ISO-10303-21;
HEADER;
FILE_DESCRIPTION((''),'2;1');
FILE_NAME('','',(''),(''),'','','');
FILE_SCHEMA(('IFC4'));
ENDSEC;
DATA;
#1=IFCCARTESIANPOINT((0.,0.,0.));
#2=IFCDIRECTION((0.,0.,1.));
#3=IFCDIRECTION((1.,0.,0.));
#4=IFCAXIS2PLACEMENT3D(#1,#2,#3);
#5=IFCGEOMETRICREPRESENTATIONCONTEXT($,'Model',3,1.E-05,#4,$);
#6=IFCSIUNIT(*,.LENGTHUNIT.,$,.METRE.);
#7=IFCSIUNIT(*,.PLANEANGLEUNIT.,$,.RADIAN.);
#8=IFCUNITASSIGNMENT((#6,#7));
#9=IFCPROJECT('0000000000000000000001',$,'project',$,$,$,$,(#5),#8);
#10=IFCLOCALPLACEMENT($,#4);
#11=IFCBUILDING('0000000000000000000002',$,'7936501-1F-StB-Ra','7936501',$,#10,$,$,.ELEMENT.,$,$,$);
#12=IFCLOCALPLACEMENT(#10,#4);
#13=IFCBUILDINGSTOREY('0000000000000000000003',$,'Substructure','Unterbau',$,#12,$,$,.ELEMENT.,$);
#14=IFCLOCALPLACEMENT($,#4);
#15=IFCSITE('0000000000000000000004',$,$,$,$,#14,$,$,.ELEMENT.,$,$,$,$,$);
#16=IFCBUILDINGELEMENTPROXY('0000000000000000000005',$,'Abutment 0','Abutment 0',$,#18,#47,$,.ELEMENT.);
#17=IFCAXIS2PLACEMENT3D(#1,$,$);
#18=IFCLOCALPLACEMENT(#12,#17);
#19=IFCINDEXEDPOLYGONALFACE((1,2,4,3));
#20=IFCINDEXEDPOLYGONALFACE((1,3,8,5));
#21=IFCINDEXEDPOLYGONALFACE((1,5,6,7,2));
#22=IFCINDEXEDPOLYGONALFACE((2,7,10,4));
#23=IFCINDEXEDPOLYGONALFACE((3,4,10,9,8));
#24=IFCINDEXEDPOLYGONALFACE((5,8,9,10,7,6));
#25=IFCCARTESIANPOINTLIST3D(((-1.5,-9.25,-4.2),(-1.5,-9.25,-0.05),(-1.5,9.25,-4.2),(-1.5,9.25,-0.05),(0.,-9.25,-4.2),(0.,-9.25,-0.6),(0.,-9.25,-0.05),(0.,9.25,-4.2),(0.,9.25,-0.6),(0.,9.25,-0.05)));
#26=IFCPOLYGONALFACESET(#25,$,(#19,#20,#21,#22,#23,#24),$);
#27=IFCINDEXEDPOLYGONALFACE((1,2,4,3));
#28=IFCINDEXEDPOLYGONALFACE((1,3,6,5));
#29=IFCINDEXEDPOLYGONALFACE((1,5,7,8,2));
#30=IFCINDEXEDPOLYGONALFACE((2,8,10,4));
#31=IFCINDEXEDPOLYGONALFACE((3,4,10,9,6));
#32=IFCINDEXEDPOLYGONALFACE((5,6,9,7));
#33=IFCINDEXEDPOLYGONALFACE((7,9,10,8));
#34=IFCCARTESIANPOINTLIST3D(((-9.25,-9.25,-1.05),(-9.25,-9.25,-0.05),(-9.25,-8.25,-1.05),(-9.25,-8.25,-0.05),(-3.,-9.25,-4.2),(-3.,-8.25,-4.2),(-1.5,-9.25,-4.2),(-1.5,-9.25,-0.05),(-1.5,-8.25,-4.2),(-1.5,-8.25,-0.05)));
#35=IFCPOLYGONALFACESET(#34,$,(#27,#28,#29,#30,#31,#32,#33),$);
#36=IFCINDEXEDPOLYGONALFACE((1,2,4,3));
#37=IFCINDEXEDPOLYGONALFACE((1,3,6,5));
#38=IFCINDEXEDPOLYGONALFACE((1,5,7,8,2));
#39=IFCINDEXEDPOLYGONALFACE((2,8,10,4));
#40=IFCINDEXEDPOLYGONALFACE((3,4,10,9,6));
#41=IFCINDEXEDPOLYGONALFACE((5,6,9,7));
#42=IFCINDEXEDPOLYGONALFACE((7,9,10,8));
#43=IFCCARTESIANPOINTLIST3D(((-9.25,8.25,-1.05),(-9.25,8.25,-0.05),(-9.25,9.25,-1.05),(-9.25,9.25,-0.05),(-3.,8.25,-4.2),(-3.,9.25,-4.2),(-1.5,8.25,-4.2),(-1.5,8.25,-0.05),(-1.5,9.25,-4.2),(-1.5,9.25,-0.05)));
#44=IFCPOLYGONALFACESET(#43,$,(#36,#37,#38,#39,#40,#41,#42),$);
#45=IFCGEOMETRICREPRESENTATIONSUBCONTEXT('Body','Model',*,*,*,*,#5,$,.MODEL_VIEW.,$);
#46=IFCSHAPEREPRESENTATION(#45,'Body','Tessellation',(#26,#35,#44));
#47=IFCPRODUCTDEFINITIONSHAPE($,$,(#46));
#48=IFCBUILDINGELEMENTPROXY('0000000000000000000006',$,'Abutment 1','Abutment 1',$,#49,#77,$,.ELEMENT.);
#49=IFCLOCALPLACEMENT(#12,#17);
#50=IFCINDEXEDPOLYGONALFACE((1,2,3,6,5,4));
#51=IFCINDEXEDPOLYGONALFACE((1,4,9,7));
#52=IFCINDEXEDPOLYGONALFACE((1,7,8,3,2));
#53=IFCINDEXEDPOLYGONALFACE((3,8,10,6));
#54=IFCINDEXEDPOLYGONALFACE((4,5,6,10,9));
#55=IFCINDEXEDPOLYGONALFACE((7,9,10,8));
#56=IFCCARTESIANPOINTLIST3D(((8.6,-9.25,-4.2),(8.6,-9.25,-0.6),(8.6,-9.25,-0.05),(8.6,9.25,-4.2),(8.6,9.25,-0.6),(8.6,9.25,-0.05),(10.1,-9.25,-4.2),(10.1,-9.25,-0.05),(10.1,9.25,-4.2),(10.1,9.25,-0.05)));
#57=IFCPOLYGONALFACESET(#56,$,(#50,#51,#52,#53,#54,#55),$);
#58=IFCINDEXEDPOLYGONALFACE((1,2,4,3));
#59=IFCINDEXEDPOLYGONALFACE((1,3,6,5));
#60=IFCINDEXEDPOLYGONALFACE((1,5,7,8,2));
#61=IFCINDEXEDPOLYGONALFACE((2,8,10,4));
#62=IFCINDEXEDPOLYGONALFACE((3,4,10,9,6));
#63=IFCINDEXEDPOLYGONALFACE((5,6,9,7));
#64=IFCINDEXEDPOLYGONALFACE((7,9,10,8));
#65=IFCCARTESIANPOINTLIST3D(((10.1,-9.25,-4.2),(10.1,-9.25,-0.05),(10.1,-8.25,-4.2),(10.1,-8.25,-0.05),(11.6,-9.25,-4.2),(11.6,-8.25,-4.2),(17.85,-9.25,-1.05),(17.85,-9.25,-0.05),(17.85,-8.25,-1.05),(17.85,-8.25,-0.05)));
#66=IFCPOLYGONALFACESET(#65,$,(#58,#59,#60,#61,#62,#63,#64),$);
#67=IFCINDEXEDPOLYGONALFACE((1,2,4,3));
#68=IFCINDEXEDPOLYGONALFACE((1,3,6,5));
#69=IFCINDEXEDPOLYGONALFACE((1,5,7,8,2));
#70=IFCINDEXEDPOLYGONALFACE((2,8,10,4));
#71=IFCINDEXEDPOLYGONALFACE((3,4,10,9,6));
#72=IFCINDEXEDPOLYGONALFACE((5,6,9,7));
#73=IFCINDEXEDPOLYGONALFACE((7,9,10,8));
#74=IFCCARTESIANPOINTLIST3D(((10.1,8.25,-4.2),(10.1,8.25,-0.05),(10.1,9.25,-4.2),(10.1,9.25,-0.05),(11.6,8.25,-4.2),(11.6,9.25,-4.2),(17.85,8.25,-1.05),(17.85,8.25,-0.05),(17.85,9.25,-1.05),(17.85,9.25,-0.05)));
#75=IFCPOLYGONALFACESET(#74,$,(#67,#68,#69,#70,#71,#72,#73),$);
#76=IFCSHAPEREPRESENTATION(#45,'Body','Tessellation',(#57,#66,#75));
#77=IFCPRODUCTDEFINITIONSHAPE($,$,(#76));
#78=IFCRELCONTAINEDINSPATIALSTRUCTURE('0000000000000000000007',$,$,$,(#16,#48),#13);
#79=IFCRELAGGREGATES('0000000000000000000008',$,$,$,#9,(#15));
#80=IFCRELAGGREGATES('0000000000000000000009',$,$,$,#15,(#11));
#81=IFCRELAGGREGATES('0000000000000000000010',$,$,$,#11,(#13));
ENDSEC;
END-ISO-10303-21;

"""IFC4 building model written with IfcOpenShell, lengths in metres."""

from ifc_helpers import new_model, si_unit, frame, origin_with_axes, place, context, subcontext, project, spatial, polyline, outline, extrude, element, save


model = new_model("IFC4")

# Units and contexts
model_context = context("Model", 3, precision=1e-05, world=origin_with_axes())
body_context = subcontext(model_context, "Body", "Model", "MODEL_VIEW")
ifc_project = project(units=[si_unit("LENGTHUNIT", "METRE"), si_unit("PLANEANGLEUNIT", "RADIAN")], contexts=[model_context])

# Site, building, storey
site_placement = place(None, origin_with_axes())
site = spatial("IfcSite", under=ifc_project, at=site_placement, CompositionType="ELEMENT")
building_placement = place(None, origin_with_axes())
building = spatial("IfcBuilding", under=site, at=building_placement, Name="7936501-1F-StB-Ra", Description="7936501", CompositionType="ELEMENT")
storey_placement = place(building_placement, origin_with_axes())
storey = spatial("IfcBuildingStorey", under=building, at=storey_placement, Name="Substructure", Description="Unterbau", CompositionType="ELEMENT")

# Building element proxies
placement_1 = place(building_placement, origin_with_axes())
placement_2 = place(placement_1, frame((0.0, 0.0, 0.0), z_axis=(1.0, 0.0, 0.0), x_axis=(0.0, 1.0, 0.0)))
proxy_1_placement = place(placement_2, frame((-9.25, -0.6, 0.0), z_axis=(1.0, 0.0, 0.0), x_axis=(0.0, 0.0, 1.0)))
element("IfcBuildingElementProxy", 1, at=proxy_1_placement, inside=storey, Name="Abutment 0", Description="Abutment 0", PredefinedType="ELEMENT", context=body_context, shape_type="SweptSolid", body=[
    extrude(outline(polyline([(0.0, 0.0), (0.0, 3.6), (-1.5, 3.6), (-1.5, -0.55), (0.0, -0.55), (0.0, 0.0)])), origin_with_axes(), (0.0, 0.0, 1.0), 18.5),
    extrude(outline(polyline([(-1.5, -0.55), (-1.5, 3.6), (-3.0, 3.6), (-9.25, 0.45), (-9.25, -0.55), (-1.5, -0.55)])), origin_with_axes(), (0.0, 0.0, 1.0), 1.0),
    extrude(outline(polyline([(-1.5, -0.55), (-1.5, 3.6), (-3.0, 3.6), (-9.25, 0.45), (-9.25, -0.55), (-1.5, -0.55)])), frame((0.0, 0.0, 17.5), z_axis=(0.0, 0.0, 1.0), x_axis=(1.0, 0.0, 0.0)), (0.0, 0.0, 1.0), 1.0),
])
proxy_2_placement = place(placement_2, frame((-9.25, -0.6, 8.6), z_axis=(1.0, 0.0, 0.0), x_axis=(0.0, 0.0, 1.0)))
element("IfcBuildingElementProxy", 2, at=proxy_2_placement, inside=storey, Name="Abutment 1", Description="Abutment 1", PredefinedType="ELEMENT", context=body_context, shape_type="SweptSolid", body=[
    extrude(outline(polyline([(0.0, 0.0), (0.0, 3.6), (1.5, 3.6), (1.5, -0.55), (0.0, -0.55), (0.0, 0.0)])), origin_with_axes(), (0.0, 0.0, 1.0), 18.5),
    extrude(outline(polyline([(1.5, -0.55), (1.5, 3.6), (3.0, 3.6), (9.25, 0.45), (9.25, -0.55), (1.5, -0.55)])), origin_with_axes(), (0.0, 0.0, 1.0), 1.0),
    extrude(outline(polyline([(1.5, -0.55), (1.5, 3.6), (3.0, 3.6), (9.25, 0.45), (9.25, -0.55), (1.5, -0.55)])), frame((0.0, 0.0, 17.5), z_axis=(0.0, 0.0, 1.0), x_axis=(1.0, 0.0, 0.0)), (0.0, 0.0, 1.0), 1.0),
])

save(model, "model.ifc")
